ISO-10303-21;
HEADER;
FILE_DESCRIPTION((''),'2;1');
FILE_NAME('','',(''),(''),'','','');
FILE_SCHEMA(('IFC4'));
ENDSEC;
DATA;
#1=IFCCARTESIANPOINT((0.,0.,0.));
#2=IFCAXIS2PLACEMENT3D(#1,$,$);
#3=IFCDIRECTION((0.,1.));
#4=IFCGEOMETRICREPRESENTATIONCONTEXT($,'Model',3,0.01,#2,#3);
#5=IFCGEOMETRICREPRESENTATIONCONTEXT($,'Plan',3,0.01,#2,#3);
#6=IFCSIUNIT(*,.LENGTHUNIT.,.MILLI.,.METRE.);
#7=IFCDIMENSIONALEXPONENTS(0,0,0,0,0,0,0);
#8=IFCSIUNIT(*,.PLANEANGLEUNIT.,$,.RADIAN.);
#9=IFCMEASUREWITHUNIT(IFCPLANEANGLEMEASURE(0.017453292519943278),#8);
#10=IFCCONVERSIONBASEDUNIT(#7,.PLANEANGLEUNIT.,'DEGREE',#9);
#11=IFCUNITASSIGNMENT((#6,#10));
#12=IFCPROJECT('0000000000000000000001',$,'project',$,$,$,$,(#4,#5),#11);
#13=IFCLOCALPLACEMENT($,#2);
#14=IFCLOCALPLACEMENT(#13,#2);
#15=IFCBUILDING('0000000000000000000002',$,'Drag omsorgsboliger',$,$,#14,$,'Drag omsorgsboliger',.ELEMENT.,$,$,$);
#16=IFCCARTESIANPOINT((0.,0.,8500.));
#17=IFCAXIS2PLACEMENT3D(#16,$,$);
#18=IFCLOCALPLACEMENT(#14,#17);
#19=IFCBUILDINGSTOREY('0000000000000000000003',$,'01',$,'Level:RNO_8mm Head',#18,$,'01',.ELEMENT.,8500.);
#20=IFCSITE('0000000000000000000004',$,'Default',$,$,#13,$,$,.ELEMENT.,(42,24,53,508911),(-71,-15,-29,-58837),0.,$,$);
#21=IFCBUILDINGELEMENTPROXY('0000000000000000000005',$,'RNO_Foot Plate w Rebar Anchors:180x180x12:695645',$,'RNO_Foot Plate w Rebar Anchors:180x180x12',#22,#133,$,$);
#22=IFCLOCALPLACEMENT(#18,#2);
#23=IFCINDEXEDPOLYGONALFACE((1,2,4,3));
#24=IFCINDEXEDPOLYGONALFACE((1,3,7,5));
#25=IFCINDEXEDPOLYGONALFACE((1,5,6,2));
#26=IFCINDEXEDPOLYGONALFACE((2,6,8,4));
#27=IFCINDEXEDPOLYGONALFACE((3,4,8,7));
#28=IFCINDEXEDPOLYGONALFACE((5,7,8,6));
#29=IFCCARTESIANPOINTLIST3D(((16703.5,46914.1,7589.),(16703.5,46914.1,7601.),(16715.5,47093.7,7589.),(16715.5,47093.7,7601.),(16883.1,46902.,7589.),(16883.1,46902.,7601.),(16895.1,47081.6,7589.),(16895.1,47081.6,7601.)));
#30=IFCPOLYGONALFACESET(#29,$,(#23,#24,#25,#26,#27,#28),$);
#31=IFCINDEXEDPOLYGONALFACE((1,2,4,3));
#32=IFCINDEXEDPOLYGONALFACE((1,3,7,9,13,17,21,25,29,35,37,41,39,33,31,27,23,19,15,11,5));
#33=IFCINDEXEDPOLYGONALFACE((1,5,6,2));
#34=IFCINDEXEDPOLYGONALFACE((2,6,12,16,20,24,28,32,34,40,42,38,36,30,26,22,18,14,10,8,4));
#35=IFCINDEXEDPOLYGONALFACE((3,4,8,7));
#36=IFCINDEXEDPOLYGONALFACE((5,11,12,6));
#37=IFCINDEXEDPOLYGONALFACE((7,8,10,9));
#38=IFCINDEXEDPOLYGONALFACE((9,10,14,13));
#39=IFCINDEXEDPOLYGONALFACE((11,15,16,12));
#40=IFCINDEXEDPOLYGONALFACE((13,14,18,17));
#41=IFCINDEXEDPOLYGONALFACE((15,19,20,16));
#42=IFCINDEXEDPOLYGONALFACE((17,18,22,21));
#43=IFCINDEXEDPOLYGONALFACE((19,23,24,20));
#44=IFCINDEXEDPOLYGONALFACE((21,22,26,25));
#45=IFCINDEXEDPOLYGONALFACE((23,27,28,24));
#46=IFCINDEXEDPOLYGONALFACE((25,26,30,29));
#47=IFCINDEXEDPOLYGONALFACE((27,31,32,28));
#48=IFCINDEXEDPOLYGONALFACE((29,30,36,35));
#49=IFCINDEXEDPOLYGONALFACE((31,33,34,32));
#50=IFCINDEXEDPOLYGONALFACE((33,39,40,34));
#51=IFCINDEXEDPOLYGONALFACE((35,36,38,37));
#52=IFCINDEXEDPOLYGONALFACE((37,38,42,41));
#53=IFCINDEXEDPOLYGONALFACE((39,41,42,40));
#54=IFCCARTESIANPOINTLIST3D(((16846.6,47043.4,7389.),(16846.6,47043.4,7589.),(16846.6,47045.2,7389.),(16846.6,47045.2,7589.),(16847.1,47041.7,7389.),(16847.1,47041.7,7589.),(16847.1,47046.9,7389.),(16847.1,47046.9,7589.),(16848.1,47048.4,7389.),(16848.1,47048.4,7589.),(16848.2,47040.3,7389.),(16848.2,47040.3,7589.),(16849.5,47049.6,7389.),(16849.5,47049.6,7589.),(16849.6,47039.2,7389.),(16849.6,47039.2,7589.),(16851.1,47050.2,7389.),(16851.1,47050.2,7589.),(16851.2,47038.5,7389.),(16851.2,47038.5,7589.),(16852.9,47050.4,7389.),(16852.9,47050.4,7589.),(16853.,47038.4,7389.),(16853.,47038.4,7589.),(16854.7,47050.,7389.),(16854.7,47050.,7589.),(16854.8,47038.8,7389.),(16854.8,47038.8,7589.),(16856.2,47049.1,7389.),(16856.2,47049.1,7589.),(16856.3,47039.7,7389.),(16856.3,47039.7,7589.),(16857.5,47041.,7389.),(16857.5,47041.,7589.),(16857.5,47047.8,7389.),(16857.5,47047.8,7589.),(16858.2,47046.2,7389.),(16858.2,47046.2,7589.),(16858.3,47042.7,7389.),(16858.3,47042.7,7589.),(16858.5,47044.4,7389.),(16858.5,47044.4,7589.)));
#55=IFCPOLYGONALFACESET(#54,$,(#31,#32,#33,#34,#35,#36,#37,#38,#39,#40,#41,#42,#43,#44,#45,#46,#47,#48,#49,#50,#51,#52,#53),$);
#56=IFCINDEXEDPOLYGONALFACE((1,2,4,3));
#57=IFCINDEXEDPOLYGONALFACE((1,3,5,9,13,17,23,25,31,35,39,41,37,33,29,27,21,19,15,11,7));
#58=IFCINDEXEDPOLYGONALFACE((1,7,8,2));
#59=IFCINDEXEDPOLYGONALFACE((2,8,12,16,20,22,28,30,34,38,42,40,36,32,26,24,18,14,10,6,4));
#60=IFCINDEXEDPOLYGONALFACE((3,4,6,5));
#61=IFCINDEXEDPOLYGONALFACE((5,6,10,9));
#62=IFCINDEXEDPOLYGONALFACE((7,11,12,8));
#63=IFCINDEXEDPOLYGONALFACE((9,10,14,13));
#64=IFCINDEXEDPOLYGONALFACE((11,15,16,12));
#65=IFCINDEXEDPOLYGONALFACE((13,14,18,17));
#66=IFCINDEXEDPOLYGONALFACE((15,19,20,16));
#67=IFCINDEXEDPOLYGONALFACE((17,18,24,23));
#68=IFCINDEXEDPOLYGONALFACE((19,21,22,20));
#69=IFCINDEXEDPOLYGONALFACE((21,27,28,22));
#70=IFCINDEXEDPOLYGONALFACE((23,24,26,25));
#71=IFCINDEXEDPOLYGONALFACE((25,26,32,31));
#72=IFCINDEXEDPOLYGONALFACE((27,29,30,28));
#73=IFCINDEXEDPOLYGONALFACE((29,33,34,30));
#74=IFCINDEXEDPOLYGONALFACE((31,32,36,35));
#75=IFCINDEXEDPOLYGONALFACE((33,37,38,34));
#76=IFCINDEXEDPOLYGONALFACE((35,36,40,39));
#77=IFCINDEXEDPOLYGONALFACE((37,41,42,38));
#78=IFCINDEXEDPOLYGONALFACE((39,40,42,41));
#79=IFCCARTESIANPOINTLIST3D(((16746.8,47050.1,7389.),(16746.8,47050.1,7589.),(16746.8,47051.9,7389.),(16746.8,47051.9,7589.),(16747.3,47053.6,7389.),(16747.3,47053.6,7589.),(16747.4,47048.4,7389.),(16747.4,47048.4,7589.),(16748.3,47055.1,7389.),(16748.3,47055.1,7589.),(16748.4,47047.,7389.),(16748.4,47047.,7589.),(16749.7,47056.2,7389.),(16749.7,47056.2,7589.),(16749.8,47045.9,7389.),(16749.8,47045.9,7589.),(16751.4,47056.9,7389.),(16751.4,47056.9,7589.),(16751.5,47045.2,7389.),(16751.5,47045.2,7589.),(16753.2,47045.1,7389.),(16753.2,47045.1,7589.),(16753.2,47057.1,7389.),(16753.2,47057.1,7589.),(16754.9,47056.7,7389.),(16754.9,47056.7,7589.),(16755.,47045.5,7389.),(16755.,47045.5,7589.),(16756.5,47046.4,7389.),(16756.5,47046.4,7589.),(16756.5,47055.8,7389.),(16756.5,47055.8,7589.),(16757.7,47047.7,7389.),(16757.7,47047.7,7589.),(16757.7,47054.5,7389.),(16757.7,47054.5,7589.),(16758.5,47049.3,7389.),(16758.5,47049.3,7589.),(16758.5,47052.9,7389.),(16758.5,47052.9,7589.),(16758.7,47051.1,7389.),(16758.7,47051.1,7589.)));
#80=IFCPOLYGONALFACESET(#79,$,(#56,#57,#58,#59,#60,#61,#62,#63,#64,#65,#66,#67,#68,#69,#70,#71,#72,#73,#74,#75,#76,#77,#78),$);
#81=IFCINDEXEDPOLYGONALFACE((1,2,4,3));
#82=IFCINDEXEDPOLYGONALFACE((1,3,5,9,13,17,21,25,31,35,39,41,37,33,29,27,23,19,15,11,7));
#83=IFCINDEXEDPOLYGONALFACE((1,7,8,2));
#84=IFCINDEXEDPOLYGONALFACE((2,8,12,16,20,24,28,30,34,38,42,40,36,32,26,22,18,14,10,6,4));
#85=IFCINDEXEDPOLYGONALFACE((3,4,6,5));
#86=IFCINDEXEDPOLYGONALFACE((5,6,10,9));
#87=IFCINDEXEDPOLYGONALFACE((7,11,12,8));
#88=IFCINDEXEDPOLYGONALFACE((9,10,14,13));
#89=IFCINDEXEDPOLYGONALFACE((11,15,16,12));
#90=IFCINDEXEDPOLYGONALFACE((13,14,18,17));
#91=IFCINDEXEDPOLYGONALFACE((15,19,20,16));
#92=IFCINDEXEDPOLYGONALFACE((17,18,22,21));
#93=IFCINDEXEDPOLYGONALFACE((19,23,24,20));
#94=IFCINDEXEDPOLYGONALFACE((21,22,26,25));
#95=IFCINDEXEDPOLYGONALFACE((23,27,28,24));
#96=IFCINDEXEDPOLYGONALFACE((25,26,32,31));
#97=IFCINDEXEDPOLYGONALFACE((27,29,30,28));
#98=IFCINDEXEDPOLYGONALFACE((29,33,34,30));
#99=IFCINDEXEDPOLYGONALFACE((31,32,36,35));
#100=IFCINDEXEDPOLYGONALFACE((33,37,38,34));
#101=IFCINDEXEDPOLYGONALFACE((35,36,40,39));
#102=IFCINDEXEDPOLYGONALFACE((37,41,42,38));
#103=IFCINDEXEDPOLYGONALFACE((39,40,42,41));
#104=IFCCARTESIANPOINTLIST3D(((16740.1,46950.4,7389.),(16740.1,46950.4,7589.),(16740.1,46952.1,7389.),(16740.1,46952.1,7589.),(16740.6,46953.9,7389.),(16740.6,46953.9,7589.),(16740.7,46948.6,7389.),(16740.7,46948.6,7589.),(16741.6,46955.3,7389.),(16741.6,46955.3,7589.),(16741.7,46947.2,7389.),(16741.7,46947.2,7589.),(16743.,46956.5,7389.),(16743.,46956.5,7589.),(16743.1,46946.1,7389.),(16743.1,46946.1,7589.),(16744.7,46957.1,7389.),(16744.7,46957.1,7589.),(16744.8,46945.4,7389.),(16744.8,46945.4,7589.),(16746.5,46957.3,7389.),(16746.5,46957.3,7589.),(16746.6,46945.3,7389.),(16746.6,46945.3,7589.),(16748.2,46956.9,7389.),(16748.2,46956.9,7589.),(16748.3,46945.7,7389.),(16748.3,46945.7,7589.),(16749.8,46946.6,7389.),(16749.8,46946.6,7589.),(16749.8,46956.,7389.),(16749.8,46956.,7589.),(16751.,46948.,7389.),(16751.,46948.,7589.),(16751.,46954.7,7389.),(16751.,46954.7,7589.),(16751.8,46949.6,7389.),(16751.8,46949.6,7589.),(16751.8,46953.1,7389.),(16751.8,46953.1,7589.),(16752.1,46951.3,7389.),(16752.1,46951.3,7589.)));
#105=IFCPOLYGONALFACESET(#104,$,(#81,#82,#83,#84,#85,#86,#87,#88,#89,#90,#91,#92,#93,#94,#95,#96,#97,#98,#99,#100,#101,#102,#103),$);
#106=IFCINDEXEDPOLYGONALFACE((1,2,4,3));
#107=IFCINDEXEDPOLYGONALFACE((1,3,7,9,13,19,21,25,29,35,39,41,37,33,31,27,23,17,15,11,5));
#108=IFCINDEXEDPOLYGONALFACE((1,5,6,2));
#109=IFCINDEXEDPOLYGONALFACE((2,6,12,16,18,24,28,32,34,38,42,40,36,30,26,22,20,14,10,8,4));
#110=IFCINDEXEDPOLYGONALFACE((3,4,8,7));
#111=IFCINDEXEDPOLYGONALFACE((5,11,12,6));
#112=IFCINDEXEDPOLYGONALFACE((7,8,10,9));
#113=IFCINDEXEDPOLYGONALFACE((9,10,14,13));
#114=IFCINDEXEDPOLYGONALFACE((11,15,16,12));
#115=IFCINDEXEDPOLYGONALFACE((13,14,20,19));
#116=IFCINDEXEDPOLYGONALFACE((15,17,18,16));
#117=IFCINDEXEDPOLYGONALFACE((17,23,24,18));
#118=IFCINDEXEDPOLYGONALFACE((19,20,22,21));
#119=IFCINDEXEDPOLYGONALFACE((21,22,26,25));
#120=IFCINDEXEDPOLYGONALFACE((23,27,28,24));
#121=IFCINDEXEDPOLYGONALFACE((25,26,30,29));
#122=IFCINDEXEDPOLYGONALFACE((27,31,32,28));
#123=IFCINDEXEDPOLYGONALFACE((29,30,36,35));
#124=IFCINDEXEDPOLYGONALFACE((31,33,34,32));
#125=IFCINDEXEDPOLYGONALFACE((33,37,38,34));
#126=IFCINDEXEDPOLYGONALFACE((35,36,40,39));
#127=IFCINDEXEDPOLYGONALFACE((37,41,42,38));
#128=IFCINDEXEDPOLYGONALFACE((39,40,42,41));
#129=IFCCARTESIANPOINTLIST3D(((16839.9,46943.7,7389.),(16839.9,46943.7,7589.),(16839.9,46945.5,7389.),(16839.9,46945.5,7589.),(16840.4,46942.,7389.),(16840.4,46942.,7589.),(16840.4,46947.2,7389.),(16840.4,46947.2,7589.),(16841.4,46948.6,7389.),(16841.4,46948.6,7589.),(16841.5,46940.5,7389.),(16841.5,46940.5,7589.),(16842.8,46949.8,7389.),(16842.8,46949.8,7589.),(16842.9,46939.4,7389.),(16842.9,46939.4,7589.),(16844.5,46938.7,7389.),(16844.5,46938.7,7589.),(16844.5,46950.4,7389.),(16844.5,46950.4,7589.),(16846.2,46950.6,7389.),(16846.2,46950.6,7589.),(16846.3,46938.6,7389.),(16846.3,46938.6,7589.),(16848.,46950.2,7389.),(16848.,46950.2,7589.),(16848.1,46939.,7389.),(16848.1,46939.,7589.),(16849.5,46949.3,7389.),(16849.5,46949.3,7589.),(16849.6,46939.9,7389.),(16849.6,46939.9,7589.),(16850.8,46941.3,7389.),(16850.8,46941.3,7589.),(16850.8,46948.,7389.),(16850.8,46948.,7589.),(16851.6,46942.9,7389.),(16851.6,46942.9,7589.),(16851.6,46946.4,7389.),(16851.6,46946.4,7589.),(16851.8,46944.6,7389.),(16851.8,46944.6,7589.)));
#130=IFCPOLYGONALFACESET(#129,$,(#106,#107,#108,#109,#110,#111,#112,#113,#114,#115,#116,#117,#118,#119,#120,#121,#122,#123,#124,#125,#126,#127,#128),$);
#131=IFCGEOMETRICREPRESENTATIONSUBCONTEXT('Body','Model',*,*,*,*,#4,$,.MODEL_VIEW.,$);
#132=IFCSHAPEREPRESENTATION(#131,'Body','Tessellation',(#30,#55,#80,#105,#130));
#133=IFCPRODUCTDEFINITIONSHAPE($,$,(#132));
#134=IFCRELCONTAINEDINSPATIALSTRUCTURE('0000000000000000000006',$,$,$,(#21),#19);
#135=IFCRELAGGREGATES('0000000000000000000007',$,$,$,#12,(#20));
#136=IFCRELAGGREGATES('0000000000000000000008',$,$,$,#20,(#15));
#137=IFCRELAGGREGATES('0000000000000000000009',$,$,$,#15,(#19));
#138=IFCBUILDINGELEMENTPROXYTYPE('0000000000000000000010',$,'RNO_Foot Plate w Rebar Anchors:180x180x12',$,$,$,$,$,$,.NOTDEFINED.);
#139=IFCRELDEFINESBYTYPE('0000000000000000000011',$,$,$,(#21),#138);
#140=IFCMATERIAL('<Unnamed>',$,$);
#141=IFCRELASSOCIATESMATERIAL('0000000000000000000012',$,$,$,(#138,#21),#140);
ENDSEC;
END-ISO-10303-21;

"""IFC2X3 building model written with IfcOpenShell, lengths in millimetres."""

from ifc_helpers import new_model, entity, si_unit, converted_unit, direction, frame, frame_2d, origin, origin_2d_with_axis, place, context, subcontext, project, spatial, rectangle, circle, extrude, source, transform, mapped, material, type_object, type_shapes, element, save


model = new_model("IFC2X3")

# Units and contexts
model_context = context("Model", 3, precision=0.01, world=origin(), true_north=direction((0.0, 1.0)))
plan_context = context("Plan", 3, precision=0.01, world=origin(), true_north=direction((0.0, 1.0)))
body_context = subcontext(model_context, "Body", "Model", "MODEL_VIEW")
ifc_project = project(units=[si_unit("LENGTHUNIT", "METRE", prefix="MILLI"), converted_unit("PLANEANGLEUNIT", "DEGREE", entity("IfcPlaneAngleMeasure", 0.017453292519943278), si_unit("PLANEANGLEUNIT", "RADIAN"), dimensions=[0, 0, 0, 0, 0, 0, 0])], contexts=[model_context, plan_context])

# Site, building, storey
site_placement = place(None, origin())
site = spatial("IfcSite", under=ifc_project, at=site_placement, Name="Default", CompositionType="ELEMENT", RefLatitude=(42, 24, 53, 508911), RefLongitude=(-71, -15, -29, -58837), RefElevation=0.0)
building_placement = place(site_placement, origin())
building = spatial("IfcBuilding", under=site, at=building_placement, Name="Drag omsorgsboliger", LongName="Drag omsorgsboliger", CompositionType="ELEMENT")
storey_placement = place(building_placement, frame((0.0, 0.0, 8500.0)))
storey = spatial("IfcBuildingStorey", under=building, at=storey_placement, Name="01", ObjectType="Level:RNO_8mm Head", LongName="01", CompositionType="ELEMENT", Elevation=8500.0)

# Building element proxy
ifc_material_1 = material(Name="<Unnamed>")
building_element_proxy_type_1 = type_object("IfcBuildingElementProxyType", Name="RNO_Foot Plate w Rebar Anchors:180x180x12", PredefinedType="NOTDEFINED", material=ifc_material_1)
shared_shape_1 = source(origin(), body_context, "Body", "SweptSolid", [
    extrude(rectangle(XDim=180.0, YDim=180.0, at=origin_2d_with_axis()), frame((-90.0, 20.0, -12.0), z_axis=(0.0, 0.0, 1.0), x_axis=(-1.0, 0.0, 0.0)), (0.0, 0.0, 1.0), 12.0),
    extrude(circle(Radius=6.0, at=frame_2d((0.0, 0.0), x_axis=(1.0, 0.0))), frame((-40.0, -30.0, -212.0)), (0.0, 0.0, 1.0), 200.0),
    extrude(circle(Radius=6.0, at=frame_2d((0.0, 0.0), x_axis=(1.0, 0.0))), frame((-40.0, 70.0, -212.0)), (0.0, 0.0, 1.0), 200.0),
    extrude(circle(Radius=6.0, at=frame_2d((0.0, 0.0), x_axis=(1.0, 0.0))), frame((-140.0, 70.0, -212.0)), (0.0, 0.0, 1.0), 200.0),
    extrude(circle(Radius=6.0, at=frame_2d((0.0, 0.0), x_axis=(1.0, 0.0))), frame((-140.0, -30.0, -212.0)), (0.0, 0.0, 1.0), 200.0),
])
type_shapes(building_element_proxy_type_1, [shared_shape_1])
for number, where, z_axis, x_axis, name in (
    (1, (16825.3, 47086.3, 7601.0), (0.0, 0.0, 1.0), (0.066923, 0.997758, 0.0), "RNO_Foot Plate w Rebar Anchors:180x180x12:695645"),
):
    element("IfcBuildingElementProxy", number, at=place(storey_placement, frame(where, z_axis=z_axis, x_axis=x_axis)), inside=storey, type_object=building_element_proxy_type_1, material=ifc_material_1, Name=name, ObjectType="RNO_Foot Plate w Rebar Anchors:180x180x12", context=body_context, shape_type="MappedRepresentation", body=[
        mapped(shared_shape_1, transform((0.0, 0.0, 0.0), scale=1.0)),
    ])

save(model, "model.ifc")
